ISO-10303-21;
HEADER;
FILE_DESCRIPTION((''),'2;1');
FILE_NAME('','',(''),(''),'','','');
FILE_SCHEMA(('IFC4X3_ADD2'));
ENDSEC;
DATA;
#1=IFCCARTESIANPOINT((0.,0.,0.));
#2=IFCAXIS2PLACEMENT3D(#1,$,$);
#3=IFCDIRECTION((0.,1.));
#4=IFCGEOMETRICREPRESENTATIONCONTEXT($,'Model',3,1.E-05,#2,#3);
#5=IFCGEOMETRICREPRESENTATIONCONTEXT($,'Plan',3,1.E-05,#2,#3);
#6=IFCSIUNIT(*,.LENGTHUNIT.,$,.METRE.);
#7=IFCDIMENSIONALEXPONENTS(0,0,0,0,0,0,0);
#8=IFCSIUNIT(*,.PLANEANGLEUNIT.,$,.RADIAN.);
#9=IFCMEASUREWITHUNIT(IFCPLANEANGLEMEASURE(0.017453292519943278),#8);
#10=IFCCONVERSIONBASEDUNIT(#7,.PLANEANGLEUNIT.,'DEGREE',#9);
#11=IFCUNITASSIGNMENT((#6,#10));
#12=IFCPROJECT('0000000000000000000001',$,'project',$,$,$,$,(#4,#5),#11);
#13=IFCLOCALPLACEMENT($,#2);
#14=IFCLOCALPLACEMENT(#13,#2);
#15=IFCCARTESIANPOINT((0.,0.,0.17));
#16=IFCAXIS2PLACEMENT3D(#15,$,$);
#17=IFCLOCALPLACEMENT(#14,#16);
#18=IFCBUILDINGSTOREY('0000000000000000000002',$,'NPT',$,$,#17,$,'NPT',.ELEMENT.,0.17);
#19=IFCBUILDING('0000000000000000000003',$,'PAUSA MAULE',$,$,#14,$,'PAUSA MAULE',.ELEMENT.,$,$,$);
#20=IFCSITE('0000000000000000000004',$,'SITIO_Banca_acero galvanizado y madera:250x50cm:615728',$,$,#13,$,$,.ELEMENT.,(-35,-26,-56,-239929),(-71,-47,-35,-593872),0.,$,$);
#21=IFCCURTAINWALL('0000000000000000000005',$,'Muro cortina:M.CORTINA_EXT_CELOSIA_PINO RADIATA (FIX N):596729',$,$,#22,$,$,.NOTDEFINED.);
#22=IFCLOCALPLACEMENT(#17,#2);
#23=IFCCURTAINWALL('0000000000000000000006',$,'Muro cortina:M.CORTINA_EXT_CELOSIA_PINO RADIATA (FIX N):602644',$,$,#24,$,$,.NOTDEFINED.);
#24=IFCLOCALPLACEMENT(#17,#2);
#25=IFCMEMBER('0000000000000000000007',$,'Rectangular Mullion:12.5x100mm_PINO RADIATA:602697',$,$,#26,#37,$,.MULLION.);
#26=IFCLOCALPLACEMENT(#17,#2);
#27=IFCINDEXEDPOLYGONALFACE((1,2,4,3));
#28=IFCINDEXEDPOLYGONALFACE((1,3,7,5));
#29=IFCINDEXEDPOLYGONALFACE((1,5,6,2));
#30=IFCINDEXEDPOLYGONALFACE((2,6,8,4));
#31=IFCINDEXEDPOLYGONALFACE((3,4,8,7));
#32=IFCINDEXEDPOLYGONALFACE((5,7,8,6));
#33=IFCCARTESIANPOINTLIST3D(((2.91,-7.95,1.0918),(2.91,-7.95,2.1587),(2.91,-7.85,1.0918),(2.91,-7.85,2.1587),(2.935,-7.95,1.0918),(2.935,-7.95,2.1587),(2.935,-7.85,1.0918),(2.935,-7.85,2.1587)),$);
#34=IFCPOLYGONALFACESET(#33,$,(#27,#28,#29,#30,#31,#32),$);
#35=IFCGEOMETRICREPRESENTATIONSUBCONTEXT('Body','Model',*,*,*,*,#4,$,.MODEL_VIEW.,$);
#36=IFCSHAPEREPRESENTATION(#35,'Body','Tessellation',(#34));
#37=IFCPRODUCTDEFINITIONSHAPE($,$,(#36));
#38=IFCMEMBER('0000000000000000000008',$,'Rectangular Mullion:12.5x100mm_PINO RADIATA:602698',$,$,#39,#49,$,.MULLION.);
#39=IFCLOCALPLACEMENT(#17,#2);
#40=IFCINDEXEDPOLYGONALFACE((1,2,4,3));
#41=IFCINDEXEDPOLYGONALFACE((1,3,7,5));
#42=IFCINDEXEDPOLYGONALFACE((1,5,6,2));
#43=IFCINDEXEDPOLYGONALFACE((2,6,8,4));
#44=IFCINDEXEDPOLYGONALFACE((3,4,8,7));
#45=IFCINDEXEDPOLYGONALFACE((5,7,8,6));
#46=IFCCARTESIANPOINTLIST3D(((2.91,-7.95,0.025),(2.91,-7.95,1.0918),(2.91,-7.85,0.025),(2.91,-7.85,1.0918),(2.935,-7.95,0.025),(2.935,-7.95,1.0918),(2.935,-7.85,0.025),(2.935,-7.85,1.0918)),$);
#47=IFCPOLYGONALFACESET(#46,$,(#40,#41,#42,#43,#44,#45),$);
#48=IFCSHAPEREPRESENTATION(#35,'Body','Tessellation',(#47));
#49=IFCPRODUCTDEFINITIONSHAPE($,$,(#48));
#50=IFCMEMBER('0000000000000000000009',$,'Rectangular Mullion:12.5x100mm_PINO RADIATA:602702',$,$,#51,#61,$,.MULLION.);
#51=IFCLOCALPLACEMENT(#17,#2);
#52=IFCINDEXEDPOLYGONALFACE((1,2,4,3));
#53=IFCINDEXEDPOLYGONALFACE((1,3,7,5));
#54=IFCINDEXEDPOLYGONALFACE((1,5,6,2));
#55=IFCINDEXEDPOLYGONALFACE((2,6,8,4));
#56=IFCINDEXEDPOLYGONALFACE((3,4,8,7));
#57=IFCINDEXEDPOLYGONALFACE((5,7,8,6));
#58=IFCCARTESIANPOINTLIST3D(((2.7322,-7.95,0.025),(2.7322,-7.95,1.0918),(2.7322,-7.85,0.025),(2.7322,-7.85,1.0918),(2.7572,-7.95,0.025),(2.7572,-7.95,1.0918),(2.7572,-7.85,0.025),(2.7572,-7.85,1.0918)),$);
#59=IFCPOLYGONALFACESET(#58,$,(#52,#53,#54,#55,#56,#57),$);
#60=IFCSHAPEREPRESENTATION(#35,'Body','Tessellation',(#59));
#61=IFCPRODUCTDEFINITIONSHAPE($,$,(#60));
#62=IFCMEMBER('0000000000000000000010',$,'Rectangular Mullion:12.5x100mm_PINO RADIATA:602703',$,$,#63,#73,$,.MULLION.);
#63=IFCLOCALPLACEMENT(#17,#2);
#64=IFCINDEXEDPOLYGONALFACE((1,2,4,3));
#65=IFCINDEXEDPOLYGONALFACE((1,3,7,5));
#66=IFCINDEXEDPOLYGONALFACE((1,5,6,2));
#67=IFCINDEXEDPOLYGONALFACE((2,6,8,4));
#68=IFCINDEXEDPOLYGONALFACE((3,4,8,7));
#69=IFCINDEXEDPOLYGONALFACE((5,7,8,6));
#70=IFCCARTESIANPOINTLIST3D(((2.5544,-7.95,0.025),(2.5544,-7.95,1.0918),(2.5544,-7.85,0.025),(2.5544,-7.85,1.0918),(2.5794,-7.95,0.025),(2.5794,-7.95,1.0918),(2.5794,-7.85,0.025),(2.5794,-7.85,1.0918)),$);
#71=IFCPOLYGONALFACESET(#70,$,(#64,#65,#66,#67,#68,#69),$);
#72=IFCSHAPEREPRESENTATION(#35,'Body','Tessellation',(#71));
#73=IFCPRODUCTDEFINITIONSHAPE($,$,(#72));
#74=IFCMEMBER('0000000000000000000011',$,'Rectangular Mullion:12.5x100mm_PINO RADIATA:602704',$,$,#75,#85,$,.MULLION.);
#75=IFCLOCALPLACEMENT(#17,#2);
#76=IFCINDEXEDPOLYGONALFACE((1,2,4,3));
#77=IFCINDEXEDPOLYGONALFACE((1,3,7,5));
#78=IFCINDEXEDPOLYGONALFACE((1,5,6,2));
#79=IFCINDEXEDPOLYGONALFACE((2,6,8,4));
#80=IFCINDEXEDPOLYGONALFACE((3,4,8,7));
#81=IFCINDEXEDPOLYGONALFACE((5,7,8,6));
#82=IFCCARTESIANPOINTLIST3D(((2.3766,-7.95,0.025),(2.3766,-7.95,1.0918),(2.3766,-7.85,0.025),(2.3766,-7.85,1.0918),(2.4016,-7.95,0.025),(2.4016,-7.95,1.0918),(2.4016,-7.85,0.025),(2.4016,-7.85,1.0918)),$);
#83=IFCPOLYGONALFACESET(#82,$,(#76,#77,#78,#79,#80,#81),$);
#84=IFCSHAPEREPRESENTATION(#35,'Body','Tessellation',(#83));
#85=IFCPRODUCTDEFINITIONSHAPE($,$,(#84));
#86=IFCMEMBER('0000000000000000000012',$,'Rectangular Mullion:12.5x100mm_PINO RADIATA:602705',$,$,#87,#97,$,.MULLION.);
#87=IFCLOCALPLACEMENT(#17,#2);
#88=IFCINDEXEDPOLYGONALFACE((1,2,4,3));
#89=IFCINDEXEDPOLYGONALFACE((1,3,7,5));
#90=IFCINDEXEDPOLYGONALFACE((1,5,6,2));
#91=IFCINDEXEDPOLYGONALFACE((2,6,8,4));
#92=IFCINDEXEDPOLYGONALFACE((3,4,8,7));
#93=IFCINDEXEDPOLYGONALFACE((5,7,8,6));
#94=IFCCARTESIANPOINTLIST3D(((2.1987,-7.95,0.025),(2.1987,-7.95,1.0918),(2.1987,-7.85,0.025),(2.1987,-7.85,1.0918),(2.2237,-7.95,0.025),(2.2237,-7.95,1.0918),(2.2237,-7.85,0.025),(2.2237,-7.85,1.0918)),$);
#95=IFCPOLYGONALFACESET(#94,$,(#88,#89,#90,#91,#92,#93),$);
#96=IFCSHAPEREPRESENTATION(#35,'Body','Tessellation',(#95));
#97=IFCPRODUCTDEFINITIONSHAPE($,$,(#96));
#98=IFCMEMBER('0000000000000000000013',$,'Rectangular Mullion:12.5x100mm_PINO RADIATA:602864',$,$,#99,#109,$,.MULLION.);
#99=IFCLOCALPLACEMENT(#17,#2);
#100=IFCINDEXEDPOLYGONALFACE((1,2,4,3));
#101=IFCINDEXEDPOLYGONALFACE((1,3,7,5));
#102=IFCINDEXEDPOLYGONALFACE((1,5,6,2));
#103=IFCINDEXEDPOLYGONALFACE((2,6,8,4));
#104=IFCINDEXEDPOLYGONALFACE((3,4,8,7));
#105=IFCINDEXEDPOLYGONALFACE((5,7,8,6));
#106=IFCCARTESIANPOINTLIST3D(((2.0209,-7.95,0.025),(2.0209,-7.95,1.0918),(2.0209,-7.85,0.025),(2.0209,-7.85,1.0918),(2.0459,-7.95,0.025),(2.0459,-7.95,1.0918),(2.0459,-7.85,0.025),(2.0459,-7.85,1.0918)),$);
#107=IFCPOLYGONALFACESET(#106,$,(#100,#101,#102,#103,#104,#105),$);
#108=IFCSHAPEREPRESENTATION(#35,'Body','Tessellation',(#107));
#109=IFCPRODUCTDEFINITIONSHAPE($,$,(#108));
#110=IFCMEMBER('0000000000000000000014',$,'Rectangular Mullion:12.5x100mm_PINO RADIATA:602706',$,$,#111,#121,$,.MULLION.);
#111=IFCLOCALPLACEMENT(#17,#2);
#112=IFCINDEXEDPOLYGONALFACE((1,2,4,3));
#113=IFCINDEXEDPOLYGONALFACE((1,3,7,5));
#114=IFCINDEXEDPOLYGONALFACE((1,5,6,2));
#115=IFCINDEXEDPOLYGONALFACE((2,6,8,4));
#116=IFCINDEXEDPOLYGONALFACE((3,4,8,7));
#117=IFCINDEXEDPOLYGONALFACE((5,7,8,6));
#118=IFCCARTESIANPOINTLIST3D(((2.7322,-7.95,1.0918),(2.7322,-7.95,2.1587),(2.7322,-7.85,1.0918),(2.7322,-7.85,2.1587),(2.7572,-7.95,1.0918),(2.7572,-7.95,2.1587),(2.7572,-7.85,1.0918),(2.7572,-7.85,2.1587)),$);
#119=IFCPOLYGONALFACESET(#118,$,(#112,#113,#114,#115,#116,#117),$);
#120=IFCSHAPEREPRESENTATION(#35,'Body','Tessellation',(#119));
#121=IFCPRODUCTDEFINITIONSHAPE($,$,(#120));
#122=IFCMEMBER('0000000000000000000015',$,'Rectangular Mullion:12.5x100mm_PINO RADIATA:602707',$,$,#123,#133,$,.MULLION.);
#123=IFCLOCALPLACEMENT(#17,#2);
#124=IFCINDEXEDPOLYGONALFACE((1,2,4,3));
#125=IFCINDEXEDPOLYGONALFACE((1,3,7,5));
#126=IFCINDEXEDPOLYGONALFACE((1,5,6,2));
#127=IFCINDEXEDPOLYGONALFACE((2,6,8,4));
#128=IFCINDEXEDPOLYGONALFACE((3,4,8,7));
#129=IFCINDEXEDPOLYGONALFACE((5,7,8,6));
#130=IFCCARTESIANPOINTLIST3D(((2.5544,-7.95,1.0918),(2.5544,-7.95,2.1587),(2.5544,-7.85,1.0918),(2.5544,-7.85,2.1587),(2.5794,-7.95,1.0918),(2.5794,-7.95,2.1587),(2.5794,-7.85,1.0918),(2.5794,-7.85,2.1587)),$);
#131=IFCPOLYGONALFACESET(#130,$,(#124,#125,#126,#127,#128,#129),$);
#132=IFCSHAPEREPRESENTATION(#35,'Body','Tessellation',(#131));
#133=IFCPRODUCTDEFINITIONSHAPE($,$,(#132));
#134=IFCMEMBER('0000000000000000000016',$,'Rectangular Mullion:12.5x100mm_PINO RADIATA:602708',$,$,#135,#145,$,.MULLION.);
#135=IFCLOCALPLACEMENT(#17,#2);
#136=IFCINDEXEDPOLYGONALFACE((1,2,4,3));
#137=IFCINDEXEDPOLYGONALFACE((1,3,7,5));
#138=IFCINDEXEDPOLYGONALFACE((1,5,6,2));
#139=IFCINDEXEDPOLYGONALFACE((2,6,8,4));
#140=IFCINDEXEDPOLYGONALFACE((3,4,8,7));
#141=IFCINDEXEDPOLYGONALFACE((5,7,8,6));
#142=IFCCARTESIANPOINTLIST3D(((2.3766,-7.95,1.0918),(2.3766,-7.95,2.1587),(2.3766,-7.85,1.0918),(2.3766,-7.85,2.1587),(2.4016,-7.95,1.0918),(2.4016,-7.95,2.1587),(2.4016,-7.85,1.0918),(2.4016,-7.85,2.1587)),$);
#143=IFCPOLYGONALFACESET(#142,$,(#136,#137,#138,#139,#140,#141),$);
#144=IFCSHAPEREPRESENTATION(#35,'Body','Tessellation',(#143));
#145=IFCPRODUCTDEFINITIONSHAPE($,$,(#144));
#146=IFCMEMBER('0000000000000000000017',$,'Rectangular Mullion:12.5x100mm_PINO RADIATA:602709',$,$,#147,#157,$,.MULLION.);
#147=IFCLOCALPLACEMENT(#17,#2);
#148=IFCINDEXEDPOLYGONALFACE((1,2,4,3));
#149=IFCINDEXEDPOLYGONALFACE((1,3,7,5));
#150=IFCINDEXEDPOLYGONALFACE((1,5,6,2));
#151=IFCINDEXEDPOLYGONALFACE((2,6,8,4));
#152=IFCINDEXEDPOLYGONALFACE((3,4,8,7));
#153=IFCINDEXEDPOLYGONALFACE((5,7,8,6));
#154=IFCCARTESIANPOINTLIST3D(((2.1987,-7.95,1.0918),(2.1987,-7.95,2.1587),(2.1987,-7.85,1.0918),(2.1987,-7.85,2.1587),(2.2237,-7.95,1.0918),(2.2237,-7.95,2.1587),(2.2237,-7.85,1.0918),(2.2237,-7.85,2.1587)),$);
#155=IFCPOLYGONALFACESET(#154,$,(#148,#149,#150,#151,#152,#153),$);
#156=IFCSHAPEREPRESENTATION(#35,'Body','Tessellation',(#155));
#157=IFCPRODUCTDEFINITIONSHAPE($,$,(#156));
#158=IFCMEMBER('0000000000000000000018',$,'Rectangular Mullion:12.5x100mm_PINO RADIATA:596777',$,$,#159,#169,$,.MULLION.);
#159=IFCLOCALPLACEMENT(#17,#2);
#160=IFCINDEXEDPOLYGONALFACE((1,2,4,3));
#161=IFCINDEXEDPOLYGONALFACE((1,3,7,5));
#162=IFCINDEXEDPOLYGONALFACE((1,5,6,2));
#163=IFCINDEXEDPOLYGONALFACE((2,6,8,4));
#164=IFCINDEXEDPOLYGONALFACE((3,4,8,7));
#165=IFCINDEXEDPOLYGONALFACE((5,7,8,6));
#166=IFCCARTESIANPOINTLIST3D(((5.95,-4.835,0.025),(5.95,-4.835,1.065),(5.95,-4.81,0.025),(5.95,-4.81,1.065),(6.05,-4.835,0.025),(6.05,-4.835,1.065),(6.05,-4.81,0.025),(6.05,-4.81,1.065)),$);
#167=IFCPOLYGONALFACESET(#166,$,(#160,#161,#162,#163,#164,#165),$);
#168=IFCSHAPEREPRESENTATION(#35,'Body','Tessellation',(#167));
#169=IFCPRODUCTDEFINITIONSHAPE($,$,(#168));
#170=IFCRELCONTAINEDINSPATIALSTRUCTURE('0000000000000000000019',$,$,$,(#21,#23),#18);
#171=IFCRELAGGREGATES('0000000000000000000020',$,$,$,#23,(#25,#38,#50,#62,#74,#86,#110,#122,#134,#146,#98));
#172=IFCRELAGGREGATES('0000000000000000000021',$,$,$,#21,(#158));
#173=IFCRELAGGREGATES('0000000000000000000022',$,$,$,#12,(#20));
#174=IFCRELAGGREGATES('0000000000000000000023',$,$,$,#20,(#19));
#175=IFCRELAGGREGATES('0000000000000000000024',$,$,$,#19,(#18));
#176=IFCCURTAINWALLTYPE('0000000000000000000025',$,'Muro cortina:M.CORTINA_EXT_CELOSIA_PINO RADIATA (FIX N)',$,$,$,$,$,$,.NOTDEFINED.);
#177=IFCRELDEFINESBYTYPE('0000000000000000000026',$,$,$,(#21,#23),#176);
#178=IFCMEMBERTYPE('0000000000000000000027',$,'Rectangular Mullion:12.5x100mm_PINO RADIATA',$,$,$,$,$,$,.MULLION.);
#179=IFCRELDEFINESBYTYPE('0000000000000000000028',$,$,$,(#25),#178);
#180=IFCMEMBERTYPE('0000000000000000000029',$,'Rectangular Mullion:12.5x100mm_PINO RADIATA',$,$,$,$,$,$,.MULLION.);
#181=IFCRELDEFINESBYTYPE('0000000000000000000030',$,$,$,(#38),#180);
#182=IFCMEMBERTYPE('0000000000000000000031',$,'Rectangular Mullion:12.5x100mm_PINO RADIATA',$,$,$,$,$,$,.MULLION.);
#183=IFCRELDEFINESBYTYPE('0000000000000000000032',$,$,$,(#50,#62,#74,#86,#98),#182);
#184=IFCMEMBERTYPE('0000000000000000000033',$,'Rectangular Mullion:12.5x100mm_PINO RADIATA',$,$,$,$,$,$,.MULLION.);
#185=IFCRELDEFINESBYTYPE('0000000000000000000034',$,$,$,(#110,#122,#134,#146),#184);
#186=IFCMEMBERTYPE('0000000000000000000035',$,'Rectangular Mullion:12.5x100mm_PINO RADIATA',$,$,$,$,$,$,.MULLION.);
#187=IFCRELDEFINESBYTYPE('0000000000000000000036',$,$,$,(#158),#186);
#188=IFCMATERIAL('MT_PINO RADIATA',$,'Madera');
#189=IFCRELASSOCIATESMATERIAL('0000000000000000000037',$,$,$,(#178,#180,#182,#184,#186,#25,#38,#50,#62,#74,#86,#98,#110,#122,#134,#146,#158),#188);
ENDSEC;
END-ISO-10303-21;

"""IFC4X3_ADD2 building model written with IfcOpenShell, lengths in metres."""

from ifc_helpers import new_model, entity, si_unit, converted_unit, direction, frame, frame_2d, origin, origin_2d_with_axis, place, context, subcontext, project, spatial, rectangle, extrude, source, transform, mapped, material, material_profile, profile_set, profile_usage, type_object, type_shapes, element, aggregate, save


model = new_model("IFC4X3_ADD2")

# Units and contexts
model_context = context("Model", 3, precision=1e-05, world=origin(), true_north=direction((0.0, 1.0)))
plan_context = context("Plan", 3, precision=1e-05, world=origin(), true_north=direction((0.0, 1.0)))
body_context = subcontext(model_context, "Body", "Model", "MODEL_VIEW")
ifc_project = project(units=[si_unit("LENGTHUNIT", "METRE"), converted_unit("PLANEANGLEUNIT", "DEGREE", entity("IfcPlaneAngleMeasure", 0.017453292519943278), si_unit("PLANEANGLEUNIT", "RADIAN"), dimensions=[0, 0, 0, 0, 0, 0, 0])], contexts=[model_context, plan_context])

# Site, building, storey
site_placement = place(None, origin())
site = spatial("IfcSite", under=ifc_project, at=site_placement, Name="SITIO_Banca_acero galvanizado y madera:250x50cm:615728", CompositionType="ELEMENT", RefLatitude=(-35, -26, -56, -239929), RefLongitude=(-71, -47, -35, -593872), RefElevation=0.0)
building_placement = place(site_placement, origin())
building = spatial("IfcBuilding", under=site, at=building_placement, Name="PAUSA MAULE", LongName="PAUSA MAULE", CompositionType="ELEMENT")
storey_placement = place(building_placement, frame((0.0, 0.0, 0.17)))
storey = spatial("IfcBuildingStorey", under=building, at=storey_placement, Name="NPT", LongName="NPT", CompositionType="ELEMENT", Elevation=0.17)

# Curtain walls
curtain_wall_type = type_object("IfcCurtainWallType", Name="Muro cortina:M.CORTINA_EXT_CELOSIA_PINO RADIATA (FIX N)", PredefinedType="NOTDEFINED")
curtain_wall_1_placement = place(storey_placement, frame((0.0, 0.0, -0.17)))
curtain_wall_1 = element("IfcCurtainWall", 1, at=curtain_wall_1_placement, inside=storey, type_object=curtain_wall_type, Name="Muro cortina:M.CORTINA_EXT_CELOSIA_PINO RADIATA (FIX N):596729", PredefinedType="NOTDEFINED")
ifc_material = material(Name="MT_PINO RADIATA", Category="Madera")
ifc_material_profile = material_profile(ifc_material, rectangle(XDim=0.025, YDim=0.1, at=frame_2d((0.0, 0.0), x_axis=(1.0, 0.0))), Name="12.5x100mm_PINO RADIATA")
ifc_profile_set = profile_set([ifc_material_profile], Name="12.5x100mm_PINO RADIATA")
ifc_profile_usage = profile_usage(ifc_profile_set)
curtain_wall_2_placement = place(storey_placement, frame((0.0, 0.0, -0.17)))
curtain_wall_2 = element("IfcCurtainWall", 2, at=curtain_wall_2_placement, inside=storey, type_object=curtain_wall_type, Name="Muro cortina:M.CORTINA_EXT_CELOSIA_PINO RADIATA (FIX N):602644", PredefinedType="NOTDEFINED")

# Members
member_type_1 = type_object("IfcMemberType", Name="Rectangular Mullion:12.5x100mm_PINO RADIATA", PredefinedType="MULLION", material=ifc_profile_set)
shared_shape_1 = source(origin(), body_context, "Body", "SweptSolid", [
    extrude(rectangle(XDim=0.025, YDim=0.1, at=frame_2d((0.0, 0.0), x_axis=(1.0, 0.0))), frame((-0.0125, 0.0, -1.0668), z_axis=(0.0, 0.0, 1.0), x_axis=(-1.0, 0.0, 0.0)), (0.0, 0.0, 1.0), 1.0668),
])
type_shapes(member_type_1, [shared_shape_1])
member_1_placement = place(curtain_wall_2_placement, frame((2.935, -7.9, 2.3287)))
member_1 = element("IfcMember", 3, at=member_1_placement, type_object=member_type_1, material=ifc_profile_usage, Name="Rectangular Mullion:12.5x100mm_PINO RADIATA:602697", PredefinedType="MULLION", context=body_context, shape_type="MappedRepresentation", body=[
    mapped(shared_shape_1, transform((0.0, 0.0, 0.0), scale=1.0)),
])
member_type_2 = type_object("IfcMemberType", Name="Rectangular Mullion:12.5x100mm_PINO RADIATA", PredefinedType="MULLION", material=ifc_profile_set)
shared_shape_2 = source(origin(), body_context, "Body", "SweptSolid", [
    extrude(rectangle(XDim=0.025, YDim=0.1, at=frame_2d((0.0, 0.0), x_axis=(1.0, 0.0))), frame((-0.0125, 0.0, -1.0668), z_axis=(0.0, 0.0, 1.0), x_axis=(-1.0, 0.0, 0.0)), (0.0, 0.0, 1.0), 1.0668),
])
type_shapes(member_type_2, [shared_shape_2])
member_2_placement = place(curtain_wall_2_placement, frame((2.935, -7.9, 1.2618)))
member_2 = element("IfcMember", 4, at=member_2_placement, type_object=member_type_2, material=ifc_profile_usage, Name="Rectangular Mullion:12.5x100mm_PINO RADIATA:602698", PredefinedType="MULLION", context=body_context, shape_type="MappedRepresentation", body=[
    mapped(shared_shape_2, transform((0.0, 0.0, 0.0), scale=1.0)),
])
member_type_3 = type_object("IfcMemberType", Name="Rectangular Mullion:12.5x100mm_PINO RADIATA", PredefinedType="MULLION", material=ifc_profile_set)
shared_shape_3 = source(origin(), body_context, "Body", "SweptSolid", [
    extrude(rectangle(XDim=0.025, YDim=0.1, at=origin_2d_with_axis()), frame((0.0, 0.0, -1.0668), z_axis=(0.0, 0.0, 1.0), x_axis=(-1.0, 0.0, 0.0)), (0.0, 0.0, 1.0), 1.0668),
])
type_shapes(member_type_3, [shared_shape_3])
member_3_placement = place(curtain_wall_2_placement, frame((2.7447, -7.9, 0.195), z_axis=(0.0, 0.0, -1.0), x_axis=(-1.0, 0.0, 0.0)))
member_3 = element("IfcMember", 5, at=member_3_placement, type_object=member_type_3, material=ifc_profile_usage, Name="Rectangular Mullion:12.5x100mm_PINO RADIATA:602702", PredefinedType="MULLION", context=body_context, shape_type="MappedRepresentation", body=[
    mapped(shared_shape_3, transform((0.0, 0.0, 0.0), scale=1.0)),
])
member_4_placement = place(curtain_wall_2_placement, frame((2.5669, -7.9, 0.195), z_axis=(0.0, 0.0, -1.0), x_axis=(-1.0, 0.0, 0.0)))
member_4 = element("IfcMember", 6, at=member_4_placement, type_object=member_type_3, material=ifc_profile_usage, Name="Rectangular Mullion:12.5x100mm_PINO RADIATA:602703", PredefinedType="MULLION", context=body_context, shape_type="MappedRepresentation", body=[
    mapped(shared_shape_3, transform((0.0, 0.0, 0.0), scale=1.0)),
])
member_5_placement = place(curtain_wall_2_placement, frame((2.3891, -7.9, 0.195), z_axis=(0.0, 0.0, -1.0), x_axis=(-1.0, 0.0, 0.0)))
member_5 = element("IfcMember", 7, at=member_5_placement, type_object=member_type_3, material=ifc_profile_usage, Name="Rectangular Mullion:12.5x100mm_PINO RADIATA:602704", PredefinedType="MULLION", context=body_context, shape_type="MappedRepresentation", body=[
    mapped(shared_shape_3, transform((0.0, 0.0, 0.0), scale=1.0)),
])
member_6_placement = place(curtain_wall_2_placement, frame((2.2112, -7.9, 0.195), z_axis=(0.0, 0.0, -1.0), x_axis=(-1.0, 0.0, 0.0)))
member_6 = element("IfcMember", 8, at=member_6_placement, type_object=member_type_3, material=ifc_profile_usage, Name="Rectangular Mullion:12.5x100mm_PINO RADIATA:602705", PredefinedType="MULLION", context=body_context, shape_type="MappedRepresentation", body=[
    mapped(shared_shape_3, transform((0.0, 0.0, 0.0), scale=1.0)),
])
member_7_placement = place(curtain_wall_2_placement, frame((2.0334, -7.9, 0.195), z_axis=(0.0, 0.0, -1.0), x_axis=(-1.0, 0.0, 0.0)))
member_7 = element("IfcMember", 9, at=member_7_placement, type_object=member_type_3, material=ifc_profile_usage, Name="Rectangular Mullion:12.5x100mm_PINO RADIATA:602864", PredefinedType="MULLION", context=body_context, shape_type="MappedRepresentation", body=[
    mapped(shared_shape_3, transform((0.0, 0.0, 0.0), scale=1.0)),
])
member_type_4 = type_object("IfcMemberType", Name="Rectangular Mullion:12.5x100mm_PINO RADIATA", PredefinedType="MULLION", material=ifc_profile_set)
shared_shape_4 = source(origin(), body_context, "Body", "SweptSolid", [
    extrude(rectangle(XDim=0.025, YDim=0.1, at=origin_2d_with_axis()), frame((0.0, 0.0, -1.0668), z_axis=(0.0, 0.0, 1.0), x_axis=(-1.0, 0.0, 0.0)), (0.0, 0.0, 1.0), 1.0668),
])
type_shapes(member_type_4, [shared_shape_4])
member_8_placement = place(curtain_wall_2_placement, frame((2.7447, -7.9, 1.2618), z_axis=(0.0, 0.0, -1.0), x_axis=(-1.0, 0.0, 0.0)))
member_8 = element("IfcMember", 10, at=member_8_placement, type_object=member_type_4, material=ifc_profile_usage, Name="Rectangular Mullion:12.5x100mm_PINO RADIATA:602706", PredefinedType="MULLION", context=body_context, shape_type="MappedRepresentation", body=[
    mapped(shared_shape_4, transform((0.0, 0.0, 0.0), scale=1.0)),
])
member_9_placement = place(curtain_wall_2_placement, frame((2.5669, -7.9, 1.2618), z_axis=(0.0, 0.0, -1.0), x_axis=(-1.0, 0.0, 0.0)))
member_9 = element("IfcMember", 11, at=member_9_placement, type_object=member_type_4, material=ifc_profile_usage, Name="Rectangular Mullion:12.5x100mm_PINO RADIATA:602707", PredefinedType="MULLION", context=body_context, shape_type="MappedRepresentation", body=[
    mapped(shared_shape_4, transform((0.0, 0.0, 0.0), scale=1.0)),
])
member_10_placement = place(curtain_wall_2_placement, frame((2.3891, -7.9, 1.2618), z_axis=(0.0, 0.0, -1.0), x_axis=(-1.0, 0.0, 0.0)))
member_10 = element("IfcMember", 12, at=member_10_placement, type_object=member_type_4, material=ifc_profile_usage, Name="Rectangular Mullion:12.5x100mm_PINO RADIATA:602708", PredefinedType="MULLION", context=body_context, shape_type="MappedRepresentation", body=[
    mapped(shared_shape_4, transform((0.0, 0.0, 0.0), scale=1.0)),
])
member_11_placement = place(curtain_wall_2_placement, frame((2.2112, -7.9, 1.2618), z_axis=(0.0, 0.0, -1.0), x_axis=(-1.0, 0.0, 0.0)))
member_11 = element("IfcMember", 13, at=member_11_placement, type_object=member_type_4, material=ifc_profile_usage, Name="Rectangular Mullion:12.5x100mm_PINO RADIATA:602709", PredefinedType="MULLION", context=body_context, shape_type="MappedRepresentation", body=[
    mapped(shared_shape_4, transform((0.0, 0.0, 0.0), scale=1.0)),
])
aggregate(curtain_wall_2, [member_1, member_2, member_3, member_4, member_5, member_6, member_8, member_9, member_10, member_11, member_7])
member_type_5 = type_object("IfcMemberType", Name="Rectangular Mullion:12.5x100mm_PINO RADIATA", PredefinedType="MULLION", material=ifc_profile_set)
shared_shape_5 = source(origin(), body_context, "Body", "SweptSolid", [
    extrude(rectangle(XDim=0.025, YDim=0.1, at=origin_2d_with_axis()), frame((-0.0125, 0.0, -1.04), z_axis=(0.0, 0.0, 1.0), x_axis=(-1.0, 0.0, 0.0)), (0.0, 0.0, 1.0), 1.04),
])
type_shapes(member_type_5, [shared_shape_5])
member_12_placement = place(curtain_wall_1_placement, frame((6.0, -4.835, 0.195), z_axis=(0.0, 0.0, -1.0), x_axis=(0.0, -1.0, 0.0)))
member_12 = element("IfcMember", 14, at=member_12_placement, type_object=member_type_5, material=ifc_profile_usage, Name="Rectangular Mullion:12.5x100mm_PINO RADIATA:596777", PredefinedType="MULLION", context=body_context, shape_type="MappedRepresentation", body=[
    mapped(shared_shape_5, transform((0.0, 0.0, 0.0), scale=1.0)),
])
aggregate(curtain_wall_1, [member_12])

save(model, "model.ifc")
